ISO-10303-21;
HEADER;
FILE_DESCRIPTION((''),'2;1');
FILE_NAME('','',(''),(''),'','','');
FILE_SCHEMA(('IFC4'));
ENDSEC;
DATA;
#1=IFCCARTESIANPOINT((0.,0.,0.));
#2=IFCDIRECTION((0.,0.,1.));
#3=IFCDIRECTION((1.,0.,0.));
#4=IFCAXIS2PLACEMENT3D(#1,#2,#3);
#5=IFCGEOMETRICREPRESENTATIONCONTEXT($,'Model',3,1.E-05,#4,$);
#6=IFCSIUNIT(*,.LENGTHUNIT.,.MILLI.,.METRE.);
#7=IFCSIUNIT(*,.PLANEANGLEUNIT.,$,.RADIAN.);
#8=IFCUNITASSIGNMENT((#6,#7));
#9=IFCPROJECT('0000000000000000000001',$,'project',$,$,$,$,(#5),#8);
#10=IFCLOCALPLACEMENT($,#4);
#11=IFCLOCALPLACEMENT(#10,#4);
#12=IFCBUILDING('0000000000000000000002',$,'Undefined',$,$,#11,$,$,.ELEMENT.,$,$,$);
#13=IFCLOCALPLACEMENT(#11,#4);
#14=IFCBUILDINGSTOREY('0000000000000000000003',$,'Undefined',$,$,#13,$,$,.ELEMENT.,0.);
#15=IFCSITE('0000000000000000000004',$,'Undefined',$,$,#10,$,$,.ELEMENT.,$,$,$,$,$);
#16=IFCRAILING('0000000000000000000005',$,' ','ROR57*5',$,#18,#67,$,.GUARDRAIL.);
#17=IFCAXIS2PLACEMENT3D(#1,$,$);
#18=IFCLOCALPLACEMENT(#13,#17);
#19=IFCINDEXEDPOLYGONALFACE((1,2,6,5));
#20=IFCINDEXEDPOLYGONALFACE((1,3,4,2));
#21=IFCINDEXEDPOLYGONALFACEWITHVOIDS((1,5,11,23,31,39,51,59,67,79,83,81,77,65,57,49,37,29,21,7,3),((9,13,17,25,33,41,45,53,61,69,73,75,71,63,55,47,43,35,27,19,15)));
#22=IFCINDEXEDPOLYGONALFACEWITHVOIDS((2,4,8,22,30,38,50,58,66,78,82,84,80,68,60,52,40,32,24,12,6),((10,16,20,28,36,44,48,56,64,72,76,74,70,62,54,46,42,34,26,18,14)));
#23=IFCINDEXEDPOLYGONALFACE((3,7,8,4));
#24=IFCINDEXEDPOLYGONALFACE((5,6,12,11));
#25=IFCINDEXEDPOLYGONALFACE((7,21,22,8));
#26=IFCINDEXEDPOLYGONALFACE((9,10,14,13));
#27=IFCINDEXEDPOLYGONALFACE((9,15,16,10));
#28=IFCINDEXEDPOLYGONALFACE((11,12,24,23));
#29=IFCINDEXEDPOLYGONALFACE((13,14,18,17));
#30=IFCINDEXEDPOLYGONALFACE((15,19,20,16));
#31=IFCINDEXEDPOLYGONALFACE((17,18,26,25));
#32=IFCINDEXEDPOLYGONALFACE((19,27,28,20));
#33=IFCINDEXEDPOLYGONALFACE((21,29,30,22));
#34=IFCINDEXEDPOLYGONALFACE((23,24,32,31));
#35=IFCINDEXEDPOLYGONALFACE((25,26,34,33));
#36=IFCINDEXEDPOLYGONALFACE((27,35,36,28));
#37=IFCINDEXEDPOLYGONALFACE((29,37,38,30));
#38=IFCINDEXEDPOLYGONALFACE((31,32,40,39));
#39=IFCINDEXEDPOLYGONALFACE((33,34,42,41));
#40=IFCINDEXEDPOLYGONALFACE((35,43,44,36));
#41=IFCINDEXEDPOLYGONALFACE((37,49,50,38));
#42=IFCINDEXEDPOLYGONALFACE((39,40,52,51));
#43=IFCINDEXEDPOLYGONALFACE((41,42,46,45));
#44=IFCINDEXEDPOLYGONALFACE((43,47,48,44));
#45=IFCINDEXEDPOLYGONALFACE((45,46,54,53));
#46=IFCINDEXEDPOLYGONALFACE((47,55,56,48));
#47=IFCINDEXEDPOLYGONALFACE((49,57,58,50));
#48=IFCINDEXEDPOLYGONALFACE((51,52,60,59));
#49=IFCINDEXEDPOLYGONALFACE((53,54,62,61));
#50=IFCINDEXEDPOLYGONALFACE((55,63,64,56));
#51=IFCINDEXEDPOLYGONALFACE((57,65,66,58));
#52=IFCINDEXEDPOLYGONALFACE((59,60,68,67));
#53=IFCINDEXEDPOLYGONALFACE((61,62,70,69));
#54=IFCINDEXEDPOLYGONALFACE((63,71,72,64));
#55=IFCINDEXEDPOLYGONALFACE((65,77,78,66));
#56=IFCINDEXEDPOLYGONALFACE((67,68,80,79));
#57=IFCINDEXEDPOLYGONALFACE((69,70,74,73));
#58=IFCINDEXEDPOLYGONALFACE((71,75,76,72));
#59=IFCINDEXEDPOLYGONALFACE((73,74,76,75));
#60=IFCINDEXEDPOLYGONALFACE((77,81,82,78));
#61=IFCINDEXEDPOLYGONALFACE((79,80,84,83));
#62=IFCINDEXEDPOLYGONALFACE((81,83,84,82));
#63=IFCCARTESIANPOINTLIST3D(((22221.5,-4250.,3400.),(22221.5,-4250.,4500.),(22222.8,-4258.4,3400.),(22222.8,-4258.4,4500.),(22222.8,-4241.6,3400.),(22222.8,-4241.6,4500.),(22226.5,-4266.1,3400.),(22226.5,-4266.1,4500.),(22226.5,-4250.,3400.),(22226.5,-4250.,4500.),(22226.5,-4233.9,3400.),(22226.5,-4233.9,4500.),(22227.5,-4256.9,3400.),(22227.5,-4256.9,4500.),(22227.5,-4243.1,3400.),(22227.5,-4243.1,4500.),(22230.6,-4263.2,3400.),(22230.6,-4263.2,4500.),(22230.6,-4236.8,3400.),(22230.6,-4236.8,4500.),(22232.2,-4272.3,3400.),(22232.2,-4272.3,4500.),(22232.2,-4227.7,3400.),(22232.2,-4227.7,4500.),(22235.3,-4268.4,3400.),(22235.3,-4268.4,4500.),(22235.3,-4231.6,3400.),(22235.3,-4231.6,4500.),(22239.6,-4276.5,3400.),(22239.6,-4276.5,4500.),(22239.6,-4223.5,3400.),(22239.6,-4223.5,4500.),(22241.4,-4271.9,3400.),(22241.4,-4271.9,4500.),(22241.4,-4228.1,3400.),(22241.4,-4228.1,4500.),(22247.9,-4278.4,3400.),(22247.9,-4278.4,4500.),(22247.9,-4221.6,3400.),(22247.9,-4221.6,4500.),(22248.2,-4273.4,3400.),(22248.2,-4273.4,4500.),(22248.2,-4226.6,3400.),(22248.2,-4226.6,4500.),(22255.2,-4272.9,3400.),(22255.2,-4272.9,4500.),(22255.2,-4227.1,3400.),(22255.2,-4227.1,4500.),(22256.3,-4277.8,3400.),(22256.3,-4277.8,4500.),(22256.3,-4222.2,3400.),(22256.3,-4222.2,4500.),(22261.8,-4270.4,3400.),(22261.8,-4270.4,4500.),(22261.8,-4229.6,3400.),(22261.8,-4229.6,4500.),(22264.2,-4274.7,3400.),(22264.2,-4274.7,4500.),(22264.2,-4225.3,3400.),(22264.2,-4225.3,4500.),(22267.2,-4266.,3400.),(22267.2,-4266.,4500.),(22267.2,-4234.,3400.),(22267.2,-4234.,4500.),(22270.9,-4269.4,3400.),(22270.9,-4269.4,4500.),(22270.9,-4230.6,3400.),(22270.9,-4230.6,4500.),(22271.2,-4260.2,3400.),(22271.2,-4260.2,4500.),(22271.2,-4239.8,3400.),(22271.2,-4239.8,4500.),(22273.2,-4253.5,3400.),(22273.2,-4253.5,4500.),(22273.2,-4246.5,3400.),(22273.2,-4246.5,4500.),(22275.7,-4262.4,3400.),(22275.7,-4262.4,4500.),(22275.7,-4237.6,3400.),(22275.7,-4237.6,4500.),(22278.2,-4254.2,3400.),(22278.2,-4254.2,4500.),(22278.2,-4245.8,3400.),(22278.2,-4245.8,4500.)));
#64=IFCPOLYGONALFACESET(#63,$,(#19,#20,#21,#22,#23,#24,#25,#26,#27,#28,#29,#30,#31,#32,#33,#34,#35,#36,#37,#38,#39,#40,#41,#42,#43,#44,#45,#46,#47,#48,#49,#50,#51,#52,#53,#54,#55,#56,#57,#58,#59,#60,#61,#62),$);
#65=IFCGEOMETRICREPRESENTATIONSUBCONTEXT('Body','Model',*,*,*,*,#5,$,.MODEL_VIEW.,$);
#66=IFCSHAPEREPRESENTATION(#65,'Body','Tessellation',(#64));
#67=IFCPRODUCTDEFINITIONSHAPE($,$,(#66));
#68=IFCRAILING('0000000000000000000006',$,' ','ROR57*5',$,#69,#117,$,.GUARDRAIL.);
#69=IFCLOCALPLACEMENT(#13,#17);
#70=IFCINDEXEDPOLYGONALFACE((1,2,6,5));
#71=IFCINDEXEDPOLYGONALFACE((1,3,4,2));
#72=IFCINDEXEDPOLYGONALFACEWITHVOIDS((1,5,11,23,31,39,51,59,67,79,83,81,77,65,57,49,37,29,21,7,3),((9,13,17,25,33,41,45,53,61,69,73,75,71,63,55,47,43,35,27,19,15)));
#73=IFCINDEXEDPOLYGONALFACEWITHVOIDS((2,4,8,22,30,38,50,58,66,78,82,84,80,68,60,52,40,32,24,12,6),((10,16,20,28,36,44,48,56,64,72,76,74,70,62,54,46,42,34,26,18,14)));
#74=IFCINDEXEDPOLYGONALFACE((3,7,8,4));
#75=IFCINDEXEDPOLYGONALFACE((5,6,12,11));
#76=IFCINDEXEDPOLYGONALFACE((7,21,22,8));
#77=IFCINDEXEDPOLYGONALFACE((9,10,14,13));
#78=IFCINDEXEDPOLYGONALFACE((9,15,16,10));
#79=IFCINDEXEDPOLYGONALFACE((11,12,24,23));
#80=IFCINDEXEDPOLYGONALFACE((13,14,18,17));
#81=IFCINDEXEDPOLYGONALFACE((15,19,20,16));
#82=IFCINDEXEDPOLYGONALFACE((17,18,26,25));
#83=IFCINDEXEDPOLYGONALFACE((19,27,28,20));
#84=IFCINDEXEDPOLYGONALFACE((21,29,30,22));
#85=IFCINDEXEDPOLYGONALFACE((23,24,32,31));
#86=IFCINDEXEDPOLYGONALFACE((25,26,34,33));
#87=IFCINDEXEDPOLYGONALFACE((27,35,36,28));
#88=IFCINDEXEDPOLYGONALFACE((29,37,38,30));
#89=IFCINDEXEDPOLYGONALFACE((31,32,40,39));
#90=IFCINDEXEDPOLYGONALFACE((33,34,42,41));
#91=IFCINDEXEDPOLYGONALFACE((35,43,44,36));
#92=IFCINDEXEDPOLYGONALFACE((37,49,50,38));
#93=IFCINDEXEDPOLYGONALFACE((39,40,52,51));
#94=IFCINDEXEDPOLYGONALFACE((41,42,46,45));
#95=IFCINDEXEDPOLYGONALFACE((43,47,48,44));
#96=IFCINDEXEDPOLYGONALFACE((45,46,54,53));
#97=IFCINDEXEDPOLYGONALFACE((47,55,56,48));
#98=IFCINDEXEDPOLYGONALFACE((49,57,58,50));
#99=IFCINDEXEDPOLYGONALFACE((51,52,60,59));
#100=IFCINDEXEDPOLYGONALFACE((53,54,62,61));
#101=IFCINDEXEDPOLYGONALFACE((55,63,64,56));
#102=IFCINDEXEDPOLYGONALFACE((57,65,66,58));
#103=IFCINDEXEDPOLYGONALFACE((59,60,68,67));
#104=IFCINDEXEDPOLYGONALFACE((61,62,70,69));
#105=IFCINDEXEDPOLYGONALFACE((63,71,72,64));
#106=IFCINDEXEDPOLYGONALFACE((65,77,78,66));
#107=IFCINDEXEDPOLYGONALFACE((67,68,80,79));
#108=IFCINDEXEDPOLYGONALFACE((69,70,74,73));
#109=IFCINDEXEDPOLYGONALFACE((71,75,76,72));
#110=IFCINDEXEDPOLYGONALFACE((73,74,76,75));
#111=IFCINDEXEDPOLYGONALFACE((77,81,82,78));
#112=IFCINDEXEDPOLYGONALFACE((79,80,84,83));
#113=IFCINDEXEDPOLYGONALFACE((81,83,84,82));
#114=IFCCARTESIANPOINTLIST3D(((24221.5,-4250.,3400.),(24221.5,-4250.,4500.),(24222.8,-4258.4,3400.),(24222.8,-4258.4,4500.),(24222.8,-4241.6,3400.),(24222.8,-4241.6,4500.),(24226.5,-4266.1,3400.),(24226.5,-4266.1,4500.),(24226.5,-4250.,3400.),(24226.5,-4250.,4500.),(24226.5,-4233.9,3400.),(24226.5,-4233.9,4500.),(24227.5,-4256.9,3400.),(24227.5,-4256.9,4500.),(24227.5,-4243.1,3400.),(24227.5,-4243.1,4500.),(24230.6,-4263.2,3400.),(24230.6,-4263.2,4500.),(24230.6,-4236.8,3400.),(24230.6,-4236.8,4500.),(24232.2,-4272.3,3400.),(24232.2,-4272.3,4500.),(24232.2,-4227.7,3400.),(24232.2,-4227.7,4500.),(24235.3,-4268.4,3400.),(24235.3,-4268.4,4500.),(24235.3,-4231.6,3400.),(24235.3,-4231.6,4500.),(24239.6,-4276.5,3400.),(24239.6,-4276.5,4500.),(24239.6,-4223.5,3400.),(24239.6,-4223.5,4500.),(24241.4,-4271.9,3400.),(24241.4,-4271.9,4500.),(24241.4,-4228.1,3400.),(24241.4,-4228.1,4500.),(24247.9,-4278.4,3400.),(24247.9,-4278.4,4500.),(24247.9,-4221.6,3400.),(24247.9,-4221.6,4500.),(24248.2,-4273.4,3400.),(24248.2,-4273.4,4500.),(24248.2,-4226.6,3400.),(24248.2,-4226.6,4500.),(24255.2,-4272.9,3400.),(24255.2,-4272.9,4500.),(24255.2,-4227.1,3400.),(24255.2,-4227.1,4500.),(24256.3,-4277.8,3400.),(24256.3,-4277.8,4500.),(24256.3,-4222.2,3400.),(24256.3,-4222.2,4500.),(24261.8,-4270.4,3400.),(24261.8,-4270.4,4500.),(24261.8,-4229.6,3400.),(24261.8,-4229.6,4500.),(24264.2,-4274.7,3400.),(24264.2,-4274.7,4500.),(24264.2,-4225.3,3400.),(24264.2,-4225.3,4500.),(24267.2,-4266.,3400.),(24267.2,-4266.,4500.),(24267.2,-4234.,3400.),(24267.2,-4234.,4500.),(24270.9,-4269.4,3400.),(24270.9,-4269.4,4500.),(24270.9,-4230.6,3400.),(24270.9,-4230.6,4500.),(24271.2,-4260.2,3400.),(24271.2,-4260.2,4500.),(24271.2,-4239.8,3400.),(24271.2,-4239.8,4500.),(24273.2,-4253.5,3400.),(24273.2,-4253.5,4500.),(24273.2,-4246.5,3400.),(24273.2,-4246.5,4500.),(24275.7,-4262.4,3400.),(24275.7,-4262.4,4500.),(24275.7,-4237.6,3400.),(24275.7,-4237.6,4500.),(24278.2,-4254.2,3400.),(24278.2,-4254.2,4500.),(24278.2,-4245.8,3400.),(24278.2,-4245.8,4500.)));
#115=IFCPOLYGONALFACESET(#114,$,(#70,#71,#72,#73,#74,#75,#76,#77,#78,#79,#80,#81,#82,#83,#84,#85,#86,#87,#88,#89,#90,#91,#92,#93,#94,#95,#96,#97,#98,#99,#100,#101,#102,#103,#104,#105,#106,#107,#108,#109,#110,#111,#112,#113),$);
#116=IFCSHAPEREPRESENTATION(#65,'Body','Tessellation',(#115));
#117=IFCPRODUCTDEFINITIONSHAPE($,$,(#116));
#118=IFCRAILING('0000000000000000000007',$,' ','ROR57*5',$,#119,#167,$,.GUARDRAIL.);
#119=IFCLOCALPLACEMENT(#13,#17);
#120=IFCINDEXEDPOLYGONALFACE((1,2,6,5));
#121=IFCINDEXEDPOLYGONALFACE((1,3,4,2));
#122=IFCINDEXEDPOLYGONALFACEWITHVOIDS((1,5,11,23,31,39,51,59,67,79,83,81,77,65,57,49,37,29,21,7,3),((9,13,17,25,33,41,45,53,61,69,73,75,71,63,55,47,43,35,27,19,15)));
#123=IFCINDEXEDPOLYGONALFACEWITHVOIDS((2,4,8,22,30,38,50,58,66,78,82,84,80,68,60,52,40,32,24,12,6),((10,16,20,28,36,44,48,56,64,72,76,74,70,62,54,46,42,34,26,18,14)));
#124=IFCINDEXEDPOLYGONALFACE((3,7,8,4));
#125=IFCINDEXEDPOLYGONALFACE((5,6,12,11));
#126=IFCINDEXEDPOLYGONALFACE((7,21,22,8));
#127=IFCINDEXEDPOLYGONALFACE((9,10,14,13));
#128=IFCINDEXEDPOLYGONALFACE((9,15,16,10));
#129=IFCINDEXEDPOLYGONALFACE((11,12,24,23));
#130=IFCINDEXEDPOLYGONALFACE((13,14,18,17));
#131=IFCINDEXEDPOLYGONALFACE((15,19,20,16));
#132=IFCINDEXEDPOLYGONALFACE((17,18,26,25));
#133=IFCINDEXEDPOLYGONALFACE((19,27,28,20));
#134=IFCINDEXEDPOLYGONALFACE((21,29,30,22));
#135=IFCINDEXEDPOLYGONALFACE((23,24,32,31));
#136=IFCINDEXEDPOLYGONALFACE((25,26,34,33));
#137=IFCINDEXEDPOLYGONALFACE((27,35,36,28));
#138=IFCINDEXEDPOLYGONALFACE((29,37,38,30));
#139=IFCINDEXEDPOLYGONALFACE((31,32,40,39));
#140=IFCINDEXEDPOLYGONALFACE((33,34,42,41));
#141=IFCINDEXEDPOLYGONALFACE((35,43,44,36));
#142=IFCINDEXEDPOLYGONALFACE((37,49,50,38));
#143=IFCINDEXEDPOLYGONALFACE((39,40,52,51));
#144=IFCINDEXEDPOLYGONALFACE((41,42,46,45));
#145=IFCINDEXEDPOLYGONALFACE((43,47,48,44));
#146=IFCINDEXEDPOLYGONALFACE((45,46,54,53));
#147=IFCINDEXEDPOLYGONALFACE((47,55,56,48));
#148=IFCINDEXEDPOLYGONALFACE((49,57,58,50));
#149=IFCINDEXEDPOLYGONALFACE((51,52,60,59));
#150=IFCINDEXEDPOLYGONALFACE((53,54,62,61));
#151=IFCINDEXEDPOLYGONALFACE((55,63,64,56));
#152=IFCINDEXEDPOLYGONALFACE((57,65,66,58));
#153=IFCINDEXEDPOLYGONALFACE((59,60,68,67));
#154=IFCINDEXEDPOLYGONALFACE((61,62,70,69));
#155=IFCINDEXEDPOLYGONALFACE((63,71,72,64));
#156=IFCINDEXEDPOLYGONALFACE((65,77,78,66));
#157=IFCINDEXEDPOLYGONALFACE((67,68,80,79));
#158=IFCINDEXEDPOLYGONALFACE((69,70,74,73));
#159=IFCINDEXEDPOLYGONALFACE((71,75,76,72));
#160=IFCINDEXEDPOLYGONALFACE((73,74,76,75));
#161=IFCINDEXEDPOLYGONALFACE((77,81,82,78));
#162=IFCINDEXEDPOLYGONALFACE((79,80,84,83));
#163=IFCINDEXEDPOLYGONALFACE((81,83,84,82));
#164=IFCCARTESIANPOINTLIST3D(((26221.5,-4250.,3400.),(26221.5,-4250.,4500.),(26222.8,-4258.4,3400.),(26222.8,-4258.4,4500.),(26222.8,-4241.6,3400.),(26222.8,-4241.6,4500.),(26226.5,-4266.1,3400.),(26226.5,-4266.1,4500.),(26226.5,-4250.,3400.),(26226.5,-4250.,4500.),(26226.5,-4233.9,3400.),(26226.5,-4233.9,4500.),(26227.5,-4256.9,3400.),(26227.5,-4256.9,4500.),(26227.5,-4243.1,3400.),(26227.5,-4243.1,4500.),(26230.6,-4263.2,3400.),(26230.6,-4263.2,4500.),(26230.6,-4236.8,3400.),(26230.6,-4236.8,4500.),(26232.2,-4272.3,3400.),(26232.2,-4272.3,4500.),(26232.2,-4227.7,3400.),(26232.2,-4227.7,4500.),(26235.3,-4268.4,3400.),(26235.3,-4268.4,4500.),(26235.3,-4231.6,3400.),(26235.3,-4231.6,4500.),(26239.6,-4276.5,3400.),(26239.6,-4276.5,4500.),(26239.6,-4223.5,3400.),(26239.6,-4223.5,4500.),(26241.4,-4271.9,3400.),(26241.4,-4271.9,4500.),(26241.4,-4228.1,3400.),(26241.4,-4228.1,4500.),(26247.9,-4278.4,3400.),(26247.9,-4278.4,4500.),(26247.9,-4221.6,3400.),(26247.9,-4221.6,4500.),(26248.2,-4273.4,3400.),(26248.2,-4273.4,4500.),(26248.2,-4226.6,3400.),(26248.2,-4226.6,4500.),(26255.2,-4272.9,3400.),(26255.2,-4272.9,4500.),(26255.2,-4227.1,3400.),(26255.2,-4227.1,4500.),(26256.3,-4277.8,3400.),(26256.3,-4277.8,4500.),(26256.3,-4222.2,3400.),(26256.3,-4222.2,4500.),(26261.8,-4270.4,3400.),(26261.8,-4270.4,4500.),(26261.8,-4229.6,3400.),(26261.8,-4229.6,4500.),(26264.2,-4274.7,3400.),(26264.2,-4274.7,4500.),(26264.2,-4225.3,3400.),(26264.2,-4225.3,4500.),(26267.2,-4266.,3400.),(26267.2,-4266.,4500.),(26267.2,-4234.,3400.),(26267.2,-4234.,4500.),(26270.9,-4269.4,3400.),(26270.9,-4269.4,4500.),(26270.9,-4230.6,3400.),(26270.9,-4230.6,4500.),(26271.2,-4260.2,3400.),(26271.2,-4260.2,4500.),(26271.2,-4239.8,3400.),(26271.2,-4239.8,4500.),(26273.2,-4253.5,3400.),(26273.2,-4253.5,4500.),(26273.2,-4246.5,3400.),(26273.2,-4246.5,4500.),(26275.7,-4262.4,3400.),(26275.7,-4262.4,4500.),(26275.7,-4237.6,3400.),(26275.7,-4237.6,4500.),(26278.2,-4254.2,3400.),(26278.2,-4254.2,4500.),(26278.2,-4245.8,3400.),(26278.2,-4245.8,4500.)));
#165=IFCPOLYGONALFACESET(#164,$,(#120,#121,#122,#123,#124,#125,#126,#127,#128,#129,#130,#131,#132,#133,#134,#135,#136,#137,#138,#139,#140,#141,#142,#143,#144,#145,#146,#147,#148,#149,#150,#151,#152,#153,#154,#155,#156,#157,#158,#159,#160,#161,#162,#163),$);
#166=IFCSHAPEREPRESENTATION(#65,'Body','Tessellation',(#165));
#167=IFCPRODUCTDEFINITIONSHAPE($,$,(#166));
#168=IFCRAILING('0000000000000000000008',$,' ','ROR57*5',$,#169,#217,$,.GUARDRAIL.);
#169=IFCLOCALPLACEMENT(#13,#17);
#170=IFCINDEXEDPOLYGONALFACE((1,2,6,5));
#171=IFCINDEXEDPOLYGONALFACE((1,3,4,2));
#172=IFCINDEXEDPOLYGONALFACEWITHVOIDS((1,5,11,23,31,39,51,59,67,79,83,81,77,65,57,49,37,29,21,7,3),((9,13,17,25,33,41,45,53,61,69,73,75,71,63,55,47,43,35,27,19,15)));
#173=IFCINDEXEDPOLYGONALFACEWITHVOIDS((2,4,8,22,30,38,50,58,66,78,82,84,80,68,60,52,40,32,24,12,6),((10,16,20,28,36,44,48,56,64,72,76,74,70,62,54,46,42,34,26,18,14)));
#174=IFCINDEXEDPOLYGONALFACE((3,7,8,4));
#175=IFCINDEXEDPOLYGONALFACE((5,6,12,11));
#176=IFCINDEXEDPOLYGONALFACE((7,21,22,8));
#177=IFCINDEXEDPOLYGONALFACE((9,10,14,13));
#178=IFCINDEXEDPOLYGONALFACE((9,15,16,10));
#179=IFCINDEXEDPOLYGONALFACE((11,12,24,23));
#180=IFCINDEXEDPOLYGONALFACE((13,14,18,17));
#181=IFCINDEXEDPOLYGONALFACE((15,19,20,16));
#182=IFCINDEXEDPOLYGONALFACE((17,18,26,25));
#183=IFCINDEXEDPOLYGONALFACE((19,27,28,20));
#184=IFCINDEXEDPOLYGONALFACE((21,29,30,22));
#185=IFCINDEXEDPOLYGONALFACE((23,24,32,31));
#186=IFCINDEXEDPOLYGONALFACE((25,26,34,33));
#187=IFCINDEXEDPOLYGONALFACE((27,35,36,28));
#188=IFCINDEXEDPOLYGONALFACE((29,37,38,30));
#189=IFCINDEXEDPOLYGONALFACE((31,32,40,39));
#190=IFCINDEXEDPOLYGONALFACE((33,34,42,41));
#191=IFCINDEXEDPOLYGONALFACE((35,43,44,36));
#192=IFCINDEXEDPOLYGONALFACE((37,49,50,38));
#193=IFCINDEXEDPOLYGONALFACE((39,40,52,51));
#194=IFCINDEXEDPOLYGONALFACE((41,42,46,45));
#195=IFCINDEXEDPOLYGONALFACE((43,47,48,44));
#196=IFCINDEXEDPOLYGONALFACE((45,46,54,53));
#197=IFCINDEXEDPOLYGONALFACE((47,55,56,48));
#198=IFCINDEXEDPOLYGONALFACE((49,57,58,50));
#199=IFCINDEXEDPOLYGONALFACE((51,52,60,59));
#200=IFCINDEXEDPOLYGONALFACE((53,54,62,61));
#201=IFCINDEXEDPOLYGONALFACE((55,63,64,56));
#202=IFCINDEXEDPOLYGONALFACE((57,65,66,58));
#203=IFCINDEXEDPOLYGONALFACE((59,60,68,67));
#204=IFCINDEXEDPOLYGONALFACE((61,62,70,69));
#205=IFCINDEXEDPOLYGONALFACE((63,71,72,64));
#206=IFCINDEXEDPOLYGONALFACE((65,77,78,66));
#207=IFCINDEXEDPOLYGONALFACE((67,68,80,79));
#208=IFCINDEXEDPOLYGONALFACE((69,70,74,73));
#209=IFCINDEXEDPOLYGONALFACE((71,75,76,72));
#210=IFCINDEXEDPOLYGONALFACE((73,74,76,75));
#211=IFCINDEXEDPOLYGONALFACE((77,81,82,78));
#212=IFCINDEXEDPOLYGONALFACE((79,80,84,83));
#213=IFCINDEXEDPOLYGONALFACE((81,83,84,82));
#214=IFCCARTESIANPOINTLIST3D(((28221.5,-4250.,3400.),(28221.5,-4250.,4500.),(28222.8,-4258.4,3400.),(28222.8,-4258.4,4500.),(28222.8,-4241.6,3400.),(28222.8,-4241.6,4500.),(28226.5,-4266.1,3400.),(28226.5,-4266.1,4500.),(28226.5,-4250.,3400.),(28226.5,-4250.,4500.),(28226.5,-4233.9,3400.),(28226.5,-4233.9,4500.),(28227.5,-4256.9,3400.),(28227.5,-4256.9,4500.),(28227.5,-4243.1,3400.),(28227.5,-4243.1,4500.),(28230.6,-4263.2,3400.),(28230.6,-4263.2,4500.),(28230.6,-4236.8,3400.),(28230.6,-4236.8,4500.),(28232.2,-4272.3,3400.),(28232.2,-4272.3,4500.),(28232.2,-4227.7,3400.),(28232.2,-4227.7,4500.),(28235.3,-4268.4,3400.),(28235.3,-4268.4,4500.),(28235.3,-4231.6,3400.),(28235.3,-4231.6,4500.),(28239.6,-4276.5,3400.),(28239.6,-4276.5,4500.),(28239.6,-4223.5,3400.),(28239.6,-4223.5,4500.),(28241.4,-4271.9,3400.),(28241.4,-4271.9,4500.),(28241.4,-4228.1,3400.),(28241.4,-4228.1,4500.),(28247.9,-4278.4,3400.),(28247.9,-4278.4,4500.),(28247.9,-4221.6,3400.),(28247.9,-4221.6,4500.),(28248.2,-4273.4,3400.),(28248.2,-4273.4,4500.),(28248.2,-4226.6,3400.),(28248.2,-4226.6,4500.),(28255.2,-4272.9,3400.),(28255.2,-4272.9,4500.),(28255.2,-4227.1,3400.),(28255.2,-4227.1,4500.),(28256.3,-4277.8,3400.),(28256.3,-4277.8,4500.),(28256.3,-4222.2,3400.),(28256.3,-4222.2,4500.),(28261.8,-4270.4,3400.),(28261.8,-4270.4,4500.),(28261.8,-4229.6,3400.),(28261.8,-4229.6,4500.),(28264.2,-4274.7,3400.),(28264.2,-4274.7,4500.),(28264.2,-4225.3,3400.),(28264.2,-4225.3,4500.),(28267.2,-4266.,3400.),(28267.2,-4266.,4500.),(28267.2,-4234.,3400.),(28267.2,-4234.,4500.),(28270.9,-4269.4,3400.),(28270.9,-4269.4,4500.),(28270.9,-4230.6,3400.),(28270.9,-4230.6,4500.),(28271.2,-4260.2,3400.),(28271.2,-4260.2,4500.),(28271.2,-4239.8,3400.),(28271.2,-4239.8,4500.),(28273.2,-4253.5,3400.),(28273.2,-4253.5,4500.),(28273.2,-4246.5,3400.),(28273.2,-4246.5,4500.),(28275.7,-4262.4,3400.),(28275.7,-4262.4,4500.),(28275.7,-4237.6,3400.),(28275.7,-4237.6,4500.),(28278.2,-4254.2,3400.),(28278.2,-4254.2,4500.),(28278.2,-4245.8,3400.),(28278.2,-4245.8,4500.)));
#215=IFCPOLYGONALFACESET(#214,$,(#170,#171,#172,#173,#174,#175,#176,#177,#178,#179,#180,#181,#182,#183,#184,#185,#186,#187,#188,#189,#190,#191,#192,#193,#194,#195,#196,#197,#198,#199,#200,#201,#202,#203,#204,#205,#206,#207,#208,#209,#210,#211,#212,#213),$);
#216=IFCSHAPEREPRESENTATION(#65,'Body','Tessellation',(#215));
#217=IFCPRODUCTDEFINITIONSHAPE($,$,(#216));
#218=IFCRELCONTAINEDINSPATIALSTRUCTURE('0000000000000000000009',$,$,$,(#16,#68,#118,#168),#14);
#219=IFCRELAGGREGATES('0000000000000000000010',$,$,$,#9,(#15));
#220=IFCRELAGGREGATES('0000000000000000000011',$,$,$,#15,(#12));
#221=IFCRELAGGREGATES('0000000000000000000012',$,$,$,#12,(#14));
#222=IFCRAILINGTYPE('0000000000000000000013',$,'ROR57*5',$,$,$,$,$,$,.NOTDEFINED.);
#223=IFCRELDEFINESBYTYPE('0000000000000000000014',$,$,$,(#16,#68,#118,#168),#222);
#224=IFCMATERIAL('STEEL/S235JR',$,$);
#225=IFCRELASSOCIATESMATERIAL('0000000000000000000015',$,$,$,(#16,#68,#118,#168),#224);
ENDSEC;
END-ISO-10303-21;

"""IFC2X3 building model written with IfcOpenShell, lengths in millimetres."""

from ifc_helpers import new_model, si_unit, frame, origin_with_axes, origin_2d_with_axis, place, context, subcontext, project, spatial, hollow_circle, extrude, material, type_object, element, save


model = new_model("IFC2X3")

# Units and contexts
model_context = context("Model", 3, precision=1e-05, world=origin_with_axes())
body_context = subcontext(model_context, "Body", "Model", "MODEL_VIEW")
ifc_project = project(units=[si_unit("LENGTHUNIT", "METRE", prefix="MILLI"), si_unit("PLANEANGLEUNIT", "RADIAN")], contexts=[model_context])

# Site, building, storey
site_placement = place(None, origin_with_axes())
site = spatial("IfcSite", under=ifc_project, at=site_placement, Name="Undefined", CompositionType="ELEMENT")
building_placement = place(site_placement, origin_with_axes())
building = spatial("IfcBuilding", under=site, at=building_placement, Name="Undefined", CompositionType="ELEMENT")
storey_placement = place(building_placement, origin_with_axes())
storey = spatial("IfcBuildingStorey", under=building, at=storey_placement, Name="Undefined", CompositionType="ELEMENT", Elevation=0.0)

# Railings
ifc_material_1 = material(Name="STEEL/S235JR")
railing_type = type_object("IfcRailingType", Name="ROR57*5", PredefinedType="NOTDEFINED")
for number, where, z_axis, x_axis, name in (
    (1, (22250.0, -4250.0, 3400.0), (0.0, 1.0, 0.0), (0.0, 0.0, 1.0), " "),
    (2, (24250.0, -4250.0, 3400.0), (0.0, 1.0, 0.0), (0.0, 0.0, 1.0), " "),
    (3, (26250.0, -4250.0, 3400.0), (0.0, 1.0, 0.0), (0.0, 0.0, 1.0), " "),
    (4, (28250.0, -4250.0, 3400.0), (0.0, 1.0, 0.0), (0.0, 0.0, 1.0), " "),
):
    element("IfcRailing", number, at=place(storey_placement, frame(where, z_axis=z_axis, x_axis=x_axis)), inside=storey, type_object=railing_type, material=ifc_material_1, Name=name, Description="ROR57*5", PredefinedType="GUARDRAIL", context=body_context, shape_type="SweptSolid", body=[
        extrude(hollow_circle(Radius=28.5, WallThickness=5.0, at=origin_2d_with_axis()), frame((1100.0, 0.0, 0.0), z_axis=(-1.0, 0.0, 0.0), x_axis=(0.0, -1.0, 0.0)), (0.0, 0.0, 1.0), 1100.0),
    ])

save(model, "model.ifc")
